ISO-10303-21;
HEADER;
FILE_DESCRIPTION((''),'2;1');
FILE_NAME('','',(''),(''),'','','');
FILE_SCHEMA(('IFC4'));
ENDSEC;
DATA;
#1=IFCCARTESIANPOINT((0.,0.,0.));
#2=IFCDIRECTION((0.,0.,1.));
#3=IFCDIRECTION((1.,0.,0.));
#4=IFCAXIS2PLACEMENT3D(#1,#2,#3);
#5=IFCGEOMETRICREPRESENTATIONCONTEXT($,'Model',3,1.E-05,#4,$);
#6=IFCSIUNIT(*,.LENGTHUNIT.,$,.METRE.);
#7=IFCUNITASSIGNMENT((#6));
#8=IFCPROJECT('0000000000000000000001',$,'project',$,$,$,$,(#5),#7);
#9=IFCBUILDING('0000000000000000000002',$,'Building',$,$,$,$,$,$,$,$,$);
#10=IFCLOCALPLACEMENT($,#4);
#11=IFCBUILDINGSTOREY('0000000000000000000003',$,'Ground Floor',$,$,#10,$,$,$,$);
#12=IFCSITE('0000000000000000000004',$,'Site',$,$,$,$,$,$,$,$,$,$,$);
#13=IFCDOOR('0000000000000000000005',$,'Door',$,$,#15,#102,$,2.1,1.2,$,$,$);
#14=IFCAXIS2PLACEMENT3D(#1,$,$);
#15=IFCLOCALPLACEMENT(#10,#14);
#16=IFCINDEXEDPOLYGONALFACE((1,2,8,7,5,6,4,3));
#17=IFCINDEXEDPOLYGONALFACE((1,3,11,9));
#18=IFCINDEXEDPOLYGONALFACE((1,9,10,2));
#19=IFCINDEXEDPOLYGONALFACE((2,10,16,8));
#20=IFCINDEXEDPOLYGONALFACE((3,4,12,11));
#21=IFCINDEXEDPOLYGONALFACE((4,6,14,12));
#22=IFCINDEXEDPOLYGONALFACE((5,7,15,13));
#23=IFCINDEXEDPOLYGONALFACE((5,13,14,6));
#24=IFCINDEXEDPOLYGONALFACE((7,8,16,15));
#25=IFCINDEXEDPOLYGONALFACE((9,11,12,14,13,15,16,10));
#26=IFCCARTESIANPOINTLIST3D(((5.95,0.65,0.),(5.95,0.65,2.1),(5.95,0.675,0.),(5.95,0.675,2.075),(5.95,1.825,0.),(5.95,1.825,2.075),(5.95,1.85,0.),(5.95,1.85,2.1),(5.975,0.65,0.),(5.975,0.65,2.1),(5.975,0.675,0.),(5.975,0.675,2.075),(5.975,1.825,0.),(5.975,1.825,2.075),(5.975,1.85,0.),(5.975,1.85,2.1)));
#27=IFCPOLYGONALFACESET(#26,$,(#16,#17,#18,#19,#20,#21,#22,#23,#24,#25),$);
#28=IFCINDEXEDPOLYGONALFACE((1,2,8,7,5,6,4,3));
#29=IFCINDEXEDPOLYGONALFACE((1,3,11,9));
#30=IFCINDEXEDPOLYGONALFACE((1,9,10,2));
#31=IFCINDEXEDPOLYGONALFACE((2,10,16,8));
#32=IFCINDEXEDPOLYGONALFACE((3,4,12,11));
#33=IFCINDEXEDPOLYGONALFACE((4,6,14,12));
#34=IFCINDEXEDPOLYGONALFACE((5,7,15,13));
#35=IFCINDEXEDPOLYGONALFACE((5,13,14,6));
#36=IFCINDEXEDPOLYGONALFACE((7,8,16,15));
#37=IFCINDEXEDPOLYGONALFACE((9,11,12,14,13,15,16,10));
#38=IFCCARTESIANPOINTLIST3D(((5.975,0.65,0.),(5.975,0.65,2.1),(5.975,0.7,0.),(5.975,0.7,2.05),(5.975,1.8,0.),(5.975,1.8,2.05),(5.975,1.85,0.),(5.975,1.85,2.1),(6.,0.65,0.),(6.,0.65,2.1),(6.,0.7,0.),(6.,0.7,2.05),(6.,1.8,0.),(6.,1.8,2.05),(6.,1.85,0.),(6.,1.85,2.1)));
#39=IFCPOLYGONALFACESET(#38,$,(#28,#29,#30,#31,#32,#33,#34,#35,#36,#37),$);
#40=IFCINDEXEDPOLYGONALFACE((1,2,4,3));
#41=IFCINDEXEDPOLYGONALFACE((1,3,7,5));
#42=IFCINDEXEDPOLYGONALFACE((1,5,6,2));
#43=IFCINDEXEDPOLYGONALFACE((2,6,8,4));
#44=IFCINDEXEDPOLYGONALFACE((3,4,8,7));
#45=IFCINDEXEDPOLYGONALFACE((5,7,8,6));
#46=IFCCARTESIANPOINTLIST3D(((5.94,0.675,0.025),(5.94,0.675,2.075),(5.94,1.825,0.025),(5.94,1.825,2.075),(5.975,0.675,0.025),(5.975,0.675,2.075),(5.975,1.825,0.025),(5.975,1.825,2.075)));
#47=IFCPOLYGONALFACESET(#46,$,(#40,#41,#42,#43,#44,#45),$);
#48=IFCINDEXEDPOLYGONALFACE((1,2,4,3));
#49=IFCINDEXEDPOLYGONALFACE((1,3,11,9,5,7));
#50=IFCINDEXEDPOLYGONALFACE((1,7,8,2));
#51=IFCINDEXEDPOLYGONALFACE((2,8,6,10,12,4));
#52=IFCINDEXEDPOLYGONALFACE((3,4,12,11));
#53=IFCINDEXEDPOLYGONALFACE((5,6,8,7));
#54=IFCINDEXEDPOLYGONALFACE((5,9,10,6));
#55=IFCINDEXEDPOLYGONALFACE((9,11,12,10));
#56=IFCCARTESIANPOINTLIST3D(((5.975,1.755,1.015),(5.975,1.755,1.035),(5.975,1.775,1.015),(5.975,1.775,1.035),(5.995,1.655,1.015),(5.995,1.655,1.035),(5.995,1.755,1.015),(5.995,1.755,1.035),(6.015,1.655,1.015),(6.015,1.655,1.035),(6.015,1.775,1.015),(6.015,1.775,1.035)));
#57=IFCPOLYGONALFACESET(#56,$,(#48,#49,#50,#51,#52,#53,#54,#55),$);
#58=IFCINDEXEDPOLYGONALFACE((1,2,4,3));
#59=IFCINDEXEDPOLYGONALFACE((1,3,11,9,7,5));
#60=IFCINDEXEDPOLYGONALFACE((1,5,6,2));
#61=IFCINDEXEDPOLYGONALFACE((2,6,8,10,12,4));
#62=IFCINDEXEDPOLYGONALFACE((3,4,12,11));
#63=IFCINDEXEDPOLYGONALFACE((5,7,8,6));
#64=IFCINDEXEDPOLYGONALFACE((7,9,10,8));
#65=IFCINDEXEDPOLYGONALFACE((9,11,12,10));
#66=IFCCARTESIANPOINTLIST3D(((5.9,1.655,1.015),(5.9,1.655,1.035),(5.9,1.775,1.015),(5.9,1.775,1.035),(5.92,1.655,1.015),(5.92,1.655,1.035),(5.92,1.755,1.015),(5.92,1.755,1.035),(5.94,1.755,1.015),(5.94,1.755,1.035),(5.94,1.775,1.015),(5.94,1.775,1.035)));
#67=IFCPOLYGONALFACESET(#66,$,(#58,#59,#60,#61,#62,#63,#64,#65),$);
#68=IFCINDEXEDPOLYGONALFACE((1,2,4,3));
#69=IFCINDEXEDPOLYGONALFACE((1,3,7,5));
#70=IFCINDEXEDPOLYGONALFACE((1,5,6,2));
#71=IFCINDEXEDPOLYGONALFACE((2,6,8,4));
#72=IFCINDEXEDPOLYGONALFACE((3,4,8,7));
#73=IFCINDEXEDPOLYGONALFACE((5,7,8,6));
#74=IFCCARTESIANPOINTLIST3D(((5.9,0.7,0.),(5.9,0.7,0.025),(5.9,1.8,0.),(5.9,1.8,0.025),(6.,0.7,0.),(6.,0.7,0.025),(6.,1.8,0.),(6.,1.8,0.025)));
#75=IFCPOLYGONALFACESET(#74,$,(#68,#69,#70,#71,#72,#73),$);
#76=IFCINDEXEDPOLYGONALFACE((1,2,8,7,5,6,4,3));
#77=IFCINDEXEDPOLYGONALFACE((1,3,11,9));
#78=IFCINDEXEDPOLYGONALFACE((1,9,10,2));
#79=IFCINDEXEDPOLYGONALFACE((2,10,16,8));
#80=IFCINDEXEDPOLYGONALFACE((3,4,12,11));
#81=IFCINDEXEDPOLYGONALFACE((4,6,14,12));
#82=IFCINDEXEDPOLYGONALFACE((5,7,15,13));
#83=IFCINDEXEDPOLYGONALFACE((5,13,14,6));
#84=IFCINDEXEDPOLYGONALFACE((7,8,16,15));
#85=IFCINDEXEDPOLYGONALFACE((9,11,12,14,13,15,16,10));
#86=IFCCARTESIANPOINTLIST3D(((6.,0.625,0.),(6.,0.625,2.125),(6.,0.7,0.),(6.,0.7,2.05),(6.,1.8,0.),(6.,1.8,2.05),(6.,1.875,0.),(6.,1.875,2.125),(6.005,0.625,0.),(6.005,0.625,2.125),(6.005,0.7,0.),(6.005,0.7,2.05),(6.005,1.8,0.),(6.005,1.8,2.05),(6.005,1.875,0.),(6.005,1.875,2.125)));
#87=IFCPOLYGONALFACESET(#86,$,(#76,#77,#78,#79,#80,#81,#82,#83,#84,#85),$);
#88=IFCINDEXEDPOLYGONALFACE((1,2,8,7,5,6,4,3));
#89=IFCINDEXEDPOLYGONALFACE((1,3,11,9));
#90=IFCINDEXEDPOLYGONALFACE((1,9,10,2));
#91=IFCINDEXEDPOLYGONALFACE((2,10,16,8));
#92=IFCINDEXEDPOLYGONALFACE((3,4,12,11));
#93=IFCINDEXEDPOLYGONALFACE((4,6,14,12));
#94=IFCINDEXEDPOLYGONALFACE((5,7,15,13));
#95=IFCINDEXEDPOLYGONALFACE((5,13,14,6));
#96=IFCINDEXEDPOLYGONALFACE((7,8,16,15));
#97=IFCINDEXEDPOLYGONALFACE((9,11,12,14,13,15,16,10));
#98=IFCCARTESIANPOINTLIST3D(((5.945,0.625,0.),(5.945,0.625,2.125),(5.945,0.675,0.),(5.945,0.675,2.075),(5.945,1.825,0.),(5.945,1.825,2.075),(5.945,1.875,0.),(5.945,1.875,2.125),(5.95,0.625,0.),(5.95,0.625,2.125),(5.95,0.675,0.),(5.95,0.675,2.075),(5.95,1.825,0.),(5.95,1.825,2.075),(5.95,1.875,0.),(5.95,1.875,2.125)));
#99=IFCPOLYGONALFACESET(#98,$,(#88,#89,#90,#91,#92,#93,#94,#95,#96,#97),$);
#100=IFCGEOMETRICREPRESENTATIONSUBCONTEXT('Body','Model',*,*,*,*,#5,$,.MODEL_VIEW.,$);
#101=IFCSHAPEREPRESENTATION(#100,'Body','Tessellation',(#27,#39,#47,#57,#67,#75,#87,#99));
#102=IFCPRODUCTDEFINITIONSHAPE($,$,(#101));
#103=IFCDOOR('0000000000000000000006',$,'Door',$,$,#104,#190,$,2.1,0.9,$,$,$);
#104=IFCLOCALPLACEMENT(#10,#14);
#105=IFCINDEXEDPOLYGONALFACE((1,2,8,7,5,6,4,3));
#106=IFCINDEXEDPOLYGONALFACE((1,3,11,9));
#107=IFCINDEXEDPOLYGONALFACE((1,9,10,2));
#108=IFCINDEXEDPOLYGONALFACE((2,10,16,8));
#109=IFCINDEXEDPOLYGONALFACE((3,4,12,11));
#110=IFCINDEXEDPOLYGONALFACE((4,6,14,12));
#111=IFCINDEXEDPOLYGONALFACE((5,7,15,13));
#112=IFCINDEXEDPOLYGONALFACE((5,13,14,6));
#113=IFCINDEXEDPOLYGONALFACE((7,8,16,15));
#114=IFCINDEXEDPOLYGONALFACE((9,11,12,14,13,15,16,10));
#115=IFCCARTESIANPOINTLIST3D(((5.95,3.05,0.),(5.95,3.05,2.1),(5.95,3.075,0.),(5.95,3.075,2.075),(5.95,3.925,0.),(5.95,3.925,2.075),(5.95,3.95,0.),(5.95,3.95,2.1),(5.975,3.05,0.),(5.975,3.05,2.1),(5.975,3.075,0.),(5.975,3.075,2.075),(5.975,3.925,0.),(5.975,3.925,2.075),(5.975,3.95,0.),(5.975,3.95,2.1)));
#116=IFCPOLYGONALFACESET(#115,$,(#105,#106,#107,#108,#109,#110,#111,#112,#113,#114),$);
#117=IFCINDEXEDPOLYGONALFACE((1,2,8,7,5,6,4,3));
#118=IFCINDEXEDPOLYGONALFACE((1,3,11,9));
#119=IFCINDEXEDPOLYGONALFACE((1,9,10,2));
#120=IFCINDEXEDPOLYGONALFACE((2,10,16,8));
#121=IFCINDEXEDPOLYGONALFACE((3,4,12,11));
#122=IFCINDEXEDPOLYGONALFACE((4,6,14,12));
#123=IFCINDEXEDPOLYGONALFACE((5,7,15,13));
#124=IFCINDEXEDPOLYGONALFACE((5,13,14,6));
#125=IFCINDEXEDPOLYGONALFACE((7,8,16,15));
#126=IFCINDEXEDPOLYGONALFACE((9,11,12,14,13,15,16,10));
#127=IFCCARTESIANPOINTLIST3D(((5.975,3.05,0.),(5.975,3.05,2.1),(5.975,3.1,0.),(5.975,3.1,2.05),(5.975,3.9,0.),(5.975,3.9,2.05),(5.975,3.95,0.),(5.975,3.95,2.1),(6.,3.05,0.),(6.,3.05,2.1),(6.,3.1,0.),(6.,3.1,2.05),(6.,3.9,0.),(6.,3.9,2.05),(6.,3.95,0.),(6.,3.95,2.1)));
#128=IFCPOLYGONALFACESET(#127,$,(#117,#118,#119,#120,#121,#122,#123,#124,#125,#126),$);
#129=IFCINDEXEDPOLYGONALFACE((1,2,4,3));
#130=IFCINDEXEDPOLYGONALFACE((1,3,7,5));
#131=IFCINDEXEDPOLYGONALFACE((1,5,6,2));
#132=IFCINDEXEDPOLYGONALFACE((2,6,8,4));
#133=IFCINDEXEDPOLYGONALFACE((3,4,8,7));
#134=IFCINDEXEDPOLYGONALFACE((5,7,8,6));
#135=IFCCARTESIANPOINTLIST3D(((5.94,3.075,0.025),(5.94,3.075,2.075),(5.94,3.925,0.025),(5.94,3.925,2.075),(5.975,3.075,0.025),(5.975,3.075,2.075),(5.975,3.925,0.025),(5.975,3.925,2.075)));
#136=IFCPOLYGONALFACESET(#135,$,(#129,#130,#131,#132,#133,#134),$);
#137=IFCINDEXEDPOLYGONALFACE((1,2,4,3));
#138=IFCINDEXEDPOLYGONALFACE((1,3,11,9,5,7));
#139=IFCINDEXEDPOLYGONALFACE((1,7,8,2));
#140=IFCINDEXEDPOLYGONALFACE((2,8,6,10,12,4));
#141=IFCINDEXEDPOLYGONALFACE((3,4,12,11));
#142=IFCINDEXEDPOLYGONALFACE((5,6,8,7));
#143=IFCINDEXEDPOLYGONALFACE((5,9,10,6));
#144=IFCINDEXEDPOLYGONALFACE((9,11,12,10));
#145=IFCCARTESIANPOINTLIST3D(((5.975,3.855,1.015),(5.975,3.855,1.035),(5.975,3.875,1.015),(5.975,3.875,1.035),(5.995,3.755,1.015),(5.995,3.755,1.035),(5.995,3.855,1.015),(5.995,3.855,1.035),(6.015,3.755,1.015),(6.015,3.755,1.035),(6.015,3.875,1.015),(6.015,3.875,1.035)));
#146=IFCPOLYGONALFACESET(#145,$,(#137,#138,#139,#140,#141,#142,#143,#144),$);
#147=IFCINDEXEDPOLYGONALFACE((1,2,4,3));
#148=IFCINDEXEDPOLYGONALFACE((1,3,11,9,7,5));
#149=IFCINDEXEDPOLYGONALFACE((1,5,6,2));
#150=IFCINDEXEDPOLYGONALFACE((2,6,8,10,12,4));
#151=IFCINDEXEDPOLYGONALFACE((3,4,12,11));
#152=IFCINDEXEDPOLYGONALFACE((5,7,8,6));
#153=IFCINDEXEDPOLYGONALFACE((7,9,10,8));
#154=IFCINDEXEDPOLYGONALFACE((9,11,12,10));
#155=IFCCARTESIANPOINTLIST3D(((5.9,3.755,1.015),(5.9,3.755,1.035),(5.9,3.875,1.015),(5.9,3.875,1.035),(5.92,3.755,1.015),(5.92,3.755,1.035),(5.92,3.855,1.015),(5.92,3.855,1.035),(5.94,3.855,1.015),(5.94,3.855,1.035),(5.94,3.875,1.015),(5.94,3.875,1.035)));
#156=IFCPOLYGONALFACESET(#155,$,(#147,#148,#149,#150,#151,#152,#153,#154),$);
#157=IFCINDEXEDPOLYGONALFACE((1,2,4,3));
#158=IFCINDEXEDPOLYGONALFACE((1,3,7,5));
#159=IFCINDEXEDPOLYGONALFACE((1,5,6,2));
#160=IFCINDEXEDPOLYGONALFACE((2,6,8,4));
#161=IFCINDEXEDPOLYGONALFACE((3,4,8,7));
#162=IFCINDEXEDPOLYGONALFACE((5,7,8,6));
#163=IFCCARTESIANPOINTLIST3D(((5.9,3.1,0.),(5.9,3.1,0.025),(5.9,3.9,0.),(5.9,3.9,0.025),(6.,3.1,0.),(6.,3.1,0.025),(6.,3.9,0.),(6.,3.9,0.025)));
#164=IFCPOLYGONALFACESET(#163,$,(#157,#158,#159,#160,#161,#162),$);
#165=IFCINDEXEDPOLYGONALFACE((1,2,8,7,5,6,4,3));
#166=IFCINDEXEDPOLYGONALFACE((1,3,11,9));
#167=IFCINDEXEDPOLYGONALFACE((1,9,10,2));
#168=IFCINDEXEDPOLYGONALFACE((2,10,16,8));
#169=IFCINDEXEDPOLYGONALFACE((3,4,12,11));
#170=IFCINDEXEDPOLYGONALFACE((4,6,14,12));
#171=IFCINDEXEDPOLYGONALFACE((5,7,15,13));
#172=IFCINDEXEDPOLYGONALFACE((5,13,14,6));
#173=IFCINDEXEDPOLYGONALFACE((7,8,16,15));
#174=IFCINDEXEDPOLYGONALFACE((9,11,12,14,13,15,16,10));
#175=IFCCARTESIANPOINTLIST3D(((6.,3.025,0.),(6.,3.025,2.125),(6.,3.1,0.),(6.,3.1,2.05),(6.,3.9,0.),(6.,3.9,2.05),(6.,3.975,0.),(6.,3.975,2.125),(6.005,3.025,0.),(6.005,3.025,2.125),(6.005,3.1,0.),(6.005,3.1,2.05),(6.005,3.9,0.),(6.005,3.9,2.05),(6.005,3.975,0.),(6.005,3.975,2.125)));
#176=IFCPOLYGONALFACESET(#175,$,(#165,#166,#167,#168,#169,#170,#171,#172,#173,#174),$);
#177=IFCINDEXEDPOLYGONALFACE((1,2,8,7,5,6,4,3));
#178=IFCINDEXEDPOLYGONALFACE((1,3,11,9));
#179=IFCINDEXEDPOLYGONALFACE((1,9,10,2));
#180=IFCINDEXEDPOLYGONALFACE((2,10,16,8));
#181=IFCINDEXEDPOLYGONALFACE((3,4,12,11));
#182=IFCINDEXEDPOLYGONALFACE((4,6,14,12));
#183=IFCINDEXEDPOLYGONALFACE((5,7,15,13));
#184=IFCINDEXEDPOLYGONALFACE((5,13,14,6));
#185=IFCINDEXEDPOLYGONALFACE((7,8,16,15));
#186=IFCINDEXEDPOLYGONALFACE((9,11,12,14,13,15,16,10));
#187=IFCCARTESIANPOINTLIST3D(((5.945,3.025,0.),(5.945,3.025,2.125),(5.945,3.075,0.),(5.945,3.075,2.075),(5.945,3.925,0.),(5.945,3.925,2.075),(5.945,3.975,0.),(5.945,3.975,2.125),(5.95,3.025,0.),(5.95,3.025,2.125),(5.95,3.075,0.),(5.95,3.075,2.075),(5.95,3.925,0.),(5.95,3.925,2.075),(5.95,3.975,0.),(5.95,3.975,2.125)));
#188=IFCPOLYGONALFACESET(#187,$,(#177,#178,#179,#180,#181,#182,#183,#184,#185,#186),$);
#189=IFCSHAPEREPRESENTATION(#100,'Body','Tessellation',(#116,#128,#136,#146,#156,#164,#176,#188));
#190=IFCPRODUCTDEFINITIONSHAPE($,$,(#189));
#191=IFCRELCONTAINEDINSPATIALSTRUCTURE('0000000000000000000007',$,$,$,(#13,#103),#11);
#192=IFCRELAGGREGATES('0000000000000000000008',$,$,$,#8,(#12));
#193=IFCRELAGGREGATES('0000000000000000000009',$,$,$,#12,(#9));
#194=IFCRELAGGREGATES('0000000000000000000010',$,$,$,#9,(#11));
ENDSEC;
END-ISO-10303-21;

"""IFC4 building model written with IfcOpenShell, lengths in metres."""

from ifc_helpers import new_model, si_unit, frame, origin_with_axes, place, context, subcontext, project, spatial, line, indexed_curve, outline, extrude, element, save


model = new_model("IFC4")

# Units and contexts
model_context = context("Model", 3, precision=1e-05, world=origin_with_axes())
body_context = subcontext(model_context, "Body", "Model", "MODEL_VIEW")
ifc_project = project(units=[si_unit("LENGTHUNIT", "METRE")], contexts=[model_context])

# Site, building, storey
site = spatial("IfcSite", under=ifc_project, Name="Site")
building = spatial("IfcBuilding", under=site, Name="Building")
storey_placement = place(None, origin_with_axes())
storey = spatial("IfcBuildingStorey", under=building, at=storey_placement, Name="Ground Floor")

# Doors
door_1_placement = place(storey_placement, frame((6.0, 0.65, 0.0), z_axis=(0.0, 0.0, 1.0), x_axis=(0.0, 1.0, 0.0)))
element("IfcDoor", 1, at=door_1_placement, inside=storey, Name="Door", OverallHeight=2.1, OverallWidth=1.2, context=body_context, shape_type="SweptSolid", body=[
    extrude(outline(indexed_curve([(0.0, 0.0), (0.0, 2.1), (1.2, 2.1), (1.2, 0.0), (1.175, 0.0), (1.175, 2.075), (0.025, 2.075), (0.025, 0.0)], segments=[line(1, 2, 3, 4, 5, 6, 7, 8, 1)])), frame((0.0, 0.025, 0.0), z_axis=(0.0, -1.0, 0.0), x_axis=(1.0, 0.0, 0.0)), (0.0, 0.0, -1.0), 0.025),
    extrude(outline(indexed_curve([(0.0, 0.0), (0.0, 2.1), (1.2, 2.1), (1.2, 0.0), (1.15, 0.0), (1.15, 2.05), (0.05, 2.05), (0.05, 0.0)], segments=[line(1, 2, 3, 4, 5, 6, 7, 8, 1)])), frame((0.0, 0.0, 0.0), z_axis=(0.0, -1.0, 0.0), x_axis=(1.0, 0.0, 0.0)), (0.0, 0.0, -1.0), 0.025),
    extrude(outline(indexed_curve([(0.0, 0.0), (1.15, 0.0), (1.15, 0.035), (0.0, 0.035)], segments=[line(1, 2, 3, 4, 1)])), frame((0.025, 0.025, 0.025), z_axis=(0.0, 0.0, 1.0), x_axis=(1.0, 0.0, 0.0)), (0.0, 0.0, 1.0), 2.05),
    extrude(outline(indexed_curve([(0.0, 0.0), (0.0, -0.04), (-0.12, -0.04), (-0.12, -0.02), (-0.02, -0.02), (-0.02, 0.0)], segments=[line(1, 2, 3, 4, 5, 6, 1)])), frame((1.125, 0.025, 1.015), z_axis=(0.0, 0.0, 1.0), x_axis=(1.0, 0.0, 0.0)), (0.0, 0.0, 1.0), 0.02),
    extrude(outline(indexed_curve([(0.0, 0.0), (0.0, 0.04), (-0.12, 0.04), (-0.12, 0.02), (-0.02, 0.02), (-0.02, 0.0)], segments=[line(1, 2, 3, 4, 5, 6, 1)])), frame((1.125, 0.06, 1.015), z_axis=(0.0, 0.0, 1.0), x_axis=(1.0, 0.0, 0.0)), (0.0, 0.0, 1.0), 0.02),
    extrude(outline(indexed_curve([(0.0, 0.0), (1.1, 0.0), (1.1, 0.1), (0.0, 0.1)], segments=[line(1, 2, 3, 4, 1)])), frame((0.05, 0.0, 0.0), z_axis=(0.0, 0.0, 1.0), x_axis=(1.0, 0.0, 0.0)), (0.0, 0.0, 1.0), 0.025),
    extrude(outline(indexed_curve([(0.0, 0.0), (0.0, 2.125), (1.25, 2.125), (1.25, 0.0), (1.175, 0.0), (1.175, 2.05), (0.075, 2.05), (0.075, 0.0)], segments=[line(1, 2, 3, 4, 5, 6, 7, 8, 1)])), frame((-0.025, -0.005, 0.0), z_axis=(0.0, -1.0, 0.0), x_axis=(1.0, 0.0, 0.0)), (0.0, 0.0, -1.0), 0.005),
    extrude(outline(indexed_curve([(0.0, 0.0), (0.0, 2.125), (1.25, 2.125), (1.25, 0.0), (1.2, 0.0), (1.2, 2.075), (0.05, 2.075), (0.05, 0.0)], segments=[line(1, 2, 3, 4, 5, 6, 7, 8, 1)])), frame((-0.025, 0.05, 0.0), z_axis=(0.0, -1.0, 0.0), x_axis=(1.0, 0.0, 0.0)), (0.0, 0.0, -1.0), 0.005),
])
door_2_placement = place(storey_placement, frame((6.0, 3.05, 0.0), z_axis=(0.0, 0.0, 1.0), x_axis=(0.0, 1.0, 0.0)))
element("IfcDoor", 2, at=door_2_placement, inside=storey, Name="Door", OverallHeight=2.1, OverallWidth=0.9, context=body_context, shape_type="SweptSolid", body=[
    extrude(outline(indexed_curve([(0.0, 0.0), (0.0, 2.1), (0.9, 2.1), (0.9, 0.0), (0.875, 0.0), (0.875, 2.075), (0.025, 2.075), (0.025, 0.0)], segments=[line(1, 2, 3, 4, 5, 6, 7, 8, 1)])), frame((0.0, 0.025, 0.0), z_axis=(0.0, -1.0, 0.0), x_axis=(1.0, 0.0, 0.0)), (0.0, 0.0, -1.0), 0.025),
    extrude(outline(indexed_curve([(0.0, 0.0), (0.0, 2.1), (0.9, 2.1), (0.9, 0.0), (0.85, 0.0), (0.85, 2.05), (0.05, 2.05), (0.05, 0.0)], segments=[line(1, 2, 3, 4, 5, 6, 7, 8, 1)])), frame((0.0, 0.0, 0.0), z_axis=(0.0, -1.0, 0.0), x_axis=(1.0, 0.0, 0.0)), (0.0, 0.0, -1.0), 0.025),
    extrude(outline(indexed_curve([(0.0, 0.0), (0.85, 0.0), (0.85, 0.035), (0.0, 0.035)], segments=[line(1, 2, 3, 4, 1)])), frame((0.025, 0.025, 0.025), z_axis=(0.0, 0.0, 1.0), x_axis=(1.0, 0.0, 0.0)), (0.0, 0.0, 1.0), 2.05),
    extrude(outline(indexed_curve([(0.0, 0.0), (0.0, -0.04), (-0.12, -0.04), (-0.12, -0.02), (-0.02, -0.02), (-0.02, 0.0)], segments=[line(1, 2, 3, 4, 5, 6, 1)])), frame((0.825, 0.025, 1.015), z_axis=(0.0, 0.0, 1.0), x_axis=(1.0, 0.0, 0.0)), (0.0, 0.0, 1.0), 0.02),
    extrude(outline(indexed_curve([(0.0, 0.0), (0.0, 0.04), (-0.12, 0.04), (-0.12, 0.02), (-0.02, 0.02), (-0.02, 0.0)], segments=[line(1, 2, 3, 4, 5, 6, 1)])), frame((0.825, 0.06, 1.015), z_axis=(0.0, 0.0, 1.0), x_axis=(1.0, 0.0, 0.0)), (0.0, 0.0, 1.0), 0.02),
    extrude(outline(indexed_curve([(0.0, 0.0), (0.8, 0.0), (0.8, 0.1), (0.0, 0.1)], segments=[line(1, 2, 3, 4, 1)])), frame((0.05, 0.0, 0.0), z_axis=(0.0, 0.0, 1.0), x_axis=(1.0, 0.0, 0.0)), (0.0, 0.0, 1.0), 0.025),
    extrude(outline(indexed_curve([(0.0, 0.0), (0.0, 2.125), (0.95, 2.125), (0.95, 0.0), (0.875, 0.0), (0.875, 2.05), (0.075, 2.05), (0.075, 0.0)], segments=[line(1, 2, 3, 4, 5, 6, 7, 8, 1)])), frame((-0.025, -0.005, 0.0), z_axis=(0.0, -1.0, 0.0), x_axis=(1.0, 0.0, 0.0)), (0.0, 0.0, -1.0), 0.005),
    extrude(outline(indexed_curve([(0.0, 0.0), (0.0, 2.125), (0.95, 2.125), (0.95, 0.0), (0.9, 0.0), (0.9, 2.075), (0.05, 2.075), (0.05, 0.0)], segments=[line(1, 2, 3, 4, 5, 6, 7, 8, 1)])), frame((-0.025, 0.05, 0.0), z_axis=(0.0, -1.0, 0.0), x_axis=(1.0, 0.0, 0.0)), (0.0, 0.0, -1.0), 0.005),
])

save(model, "model.ifc")
